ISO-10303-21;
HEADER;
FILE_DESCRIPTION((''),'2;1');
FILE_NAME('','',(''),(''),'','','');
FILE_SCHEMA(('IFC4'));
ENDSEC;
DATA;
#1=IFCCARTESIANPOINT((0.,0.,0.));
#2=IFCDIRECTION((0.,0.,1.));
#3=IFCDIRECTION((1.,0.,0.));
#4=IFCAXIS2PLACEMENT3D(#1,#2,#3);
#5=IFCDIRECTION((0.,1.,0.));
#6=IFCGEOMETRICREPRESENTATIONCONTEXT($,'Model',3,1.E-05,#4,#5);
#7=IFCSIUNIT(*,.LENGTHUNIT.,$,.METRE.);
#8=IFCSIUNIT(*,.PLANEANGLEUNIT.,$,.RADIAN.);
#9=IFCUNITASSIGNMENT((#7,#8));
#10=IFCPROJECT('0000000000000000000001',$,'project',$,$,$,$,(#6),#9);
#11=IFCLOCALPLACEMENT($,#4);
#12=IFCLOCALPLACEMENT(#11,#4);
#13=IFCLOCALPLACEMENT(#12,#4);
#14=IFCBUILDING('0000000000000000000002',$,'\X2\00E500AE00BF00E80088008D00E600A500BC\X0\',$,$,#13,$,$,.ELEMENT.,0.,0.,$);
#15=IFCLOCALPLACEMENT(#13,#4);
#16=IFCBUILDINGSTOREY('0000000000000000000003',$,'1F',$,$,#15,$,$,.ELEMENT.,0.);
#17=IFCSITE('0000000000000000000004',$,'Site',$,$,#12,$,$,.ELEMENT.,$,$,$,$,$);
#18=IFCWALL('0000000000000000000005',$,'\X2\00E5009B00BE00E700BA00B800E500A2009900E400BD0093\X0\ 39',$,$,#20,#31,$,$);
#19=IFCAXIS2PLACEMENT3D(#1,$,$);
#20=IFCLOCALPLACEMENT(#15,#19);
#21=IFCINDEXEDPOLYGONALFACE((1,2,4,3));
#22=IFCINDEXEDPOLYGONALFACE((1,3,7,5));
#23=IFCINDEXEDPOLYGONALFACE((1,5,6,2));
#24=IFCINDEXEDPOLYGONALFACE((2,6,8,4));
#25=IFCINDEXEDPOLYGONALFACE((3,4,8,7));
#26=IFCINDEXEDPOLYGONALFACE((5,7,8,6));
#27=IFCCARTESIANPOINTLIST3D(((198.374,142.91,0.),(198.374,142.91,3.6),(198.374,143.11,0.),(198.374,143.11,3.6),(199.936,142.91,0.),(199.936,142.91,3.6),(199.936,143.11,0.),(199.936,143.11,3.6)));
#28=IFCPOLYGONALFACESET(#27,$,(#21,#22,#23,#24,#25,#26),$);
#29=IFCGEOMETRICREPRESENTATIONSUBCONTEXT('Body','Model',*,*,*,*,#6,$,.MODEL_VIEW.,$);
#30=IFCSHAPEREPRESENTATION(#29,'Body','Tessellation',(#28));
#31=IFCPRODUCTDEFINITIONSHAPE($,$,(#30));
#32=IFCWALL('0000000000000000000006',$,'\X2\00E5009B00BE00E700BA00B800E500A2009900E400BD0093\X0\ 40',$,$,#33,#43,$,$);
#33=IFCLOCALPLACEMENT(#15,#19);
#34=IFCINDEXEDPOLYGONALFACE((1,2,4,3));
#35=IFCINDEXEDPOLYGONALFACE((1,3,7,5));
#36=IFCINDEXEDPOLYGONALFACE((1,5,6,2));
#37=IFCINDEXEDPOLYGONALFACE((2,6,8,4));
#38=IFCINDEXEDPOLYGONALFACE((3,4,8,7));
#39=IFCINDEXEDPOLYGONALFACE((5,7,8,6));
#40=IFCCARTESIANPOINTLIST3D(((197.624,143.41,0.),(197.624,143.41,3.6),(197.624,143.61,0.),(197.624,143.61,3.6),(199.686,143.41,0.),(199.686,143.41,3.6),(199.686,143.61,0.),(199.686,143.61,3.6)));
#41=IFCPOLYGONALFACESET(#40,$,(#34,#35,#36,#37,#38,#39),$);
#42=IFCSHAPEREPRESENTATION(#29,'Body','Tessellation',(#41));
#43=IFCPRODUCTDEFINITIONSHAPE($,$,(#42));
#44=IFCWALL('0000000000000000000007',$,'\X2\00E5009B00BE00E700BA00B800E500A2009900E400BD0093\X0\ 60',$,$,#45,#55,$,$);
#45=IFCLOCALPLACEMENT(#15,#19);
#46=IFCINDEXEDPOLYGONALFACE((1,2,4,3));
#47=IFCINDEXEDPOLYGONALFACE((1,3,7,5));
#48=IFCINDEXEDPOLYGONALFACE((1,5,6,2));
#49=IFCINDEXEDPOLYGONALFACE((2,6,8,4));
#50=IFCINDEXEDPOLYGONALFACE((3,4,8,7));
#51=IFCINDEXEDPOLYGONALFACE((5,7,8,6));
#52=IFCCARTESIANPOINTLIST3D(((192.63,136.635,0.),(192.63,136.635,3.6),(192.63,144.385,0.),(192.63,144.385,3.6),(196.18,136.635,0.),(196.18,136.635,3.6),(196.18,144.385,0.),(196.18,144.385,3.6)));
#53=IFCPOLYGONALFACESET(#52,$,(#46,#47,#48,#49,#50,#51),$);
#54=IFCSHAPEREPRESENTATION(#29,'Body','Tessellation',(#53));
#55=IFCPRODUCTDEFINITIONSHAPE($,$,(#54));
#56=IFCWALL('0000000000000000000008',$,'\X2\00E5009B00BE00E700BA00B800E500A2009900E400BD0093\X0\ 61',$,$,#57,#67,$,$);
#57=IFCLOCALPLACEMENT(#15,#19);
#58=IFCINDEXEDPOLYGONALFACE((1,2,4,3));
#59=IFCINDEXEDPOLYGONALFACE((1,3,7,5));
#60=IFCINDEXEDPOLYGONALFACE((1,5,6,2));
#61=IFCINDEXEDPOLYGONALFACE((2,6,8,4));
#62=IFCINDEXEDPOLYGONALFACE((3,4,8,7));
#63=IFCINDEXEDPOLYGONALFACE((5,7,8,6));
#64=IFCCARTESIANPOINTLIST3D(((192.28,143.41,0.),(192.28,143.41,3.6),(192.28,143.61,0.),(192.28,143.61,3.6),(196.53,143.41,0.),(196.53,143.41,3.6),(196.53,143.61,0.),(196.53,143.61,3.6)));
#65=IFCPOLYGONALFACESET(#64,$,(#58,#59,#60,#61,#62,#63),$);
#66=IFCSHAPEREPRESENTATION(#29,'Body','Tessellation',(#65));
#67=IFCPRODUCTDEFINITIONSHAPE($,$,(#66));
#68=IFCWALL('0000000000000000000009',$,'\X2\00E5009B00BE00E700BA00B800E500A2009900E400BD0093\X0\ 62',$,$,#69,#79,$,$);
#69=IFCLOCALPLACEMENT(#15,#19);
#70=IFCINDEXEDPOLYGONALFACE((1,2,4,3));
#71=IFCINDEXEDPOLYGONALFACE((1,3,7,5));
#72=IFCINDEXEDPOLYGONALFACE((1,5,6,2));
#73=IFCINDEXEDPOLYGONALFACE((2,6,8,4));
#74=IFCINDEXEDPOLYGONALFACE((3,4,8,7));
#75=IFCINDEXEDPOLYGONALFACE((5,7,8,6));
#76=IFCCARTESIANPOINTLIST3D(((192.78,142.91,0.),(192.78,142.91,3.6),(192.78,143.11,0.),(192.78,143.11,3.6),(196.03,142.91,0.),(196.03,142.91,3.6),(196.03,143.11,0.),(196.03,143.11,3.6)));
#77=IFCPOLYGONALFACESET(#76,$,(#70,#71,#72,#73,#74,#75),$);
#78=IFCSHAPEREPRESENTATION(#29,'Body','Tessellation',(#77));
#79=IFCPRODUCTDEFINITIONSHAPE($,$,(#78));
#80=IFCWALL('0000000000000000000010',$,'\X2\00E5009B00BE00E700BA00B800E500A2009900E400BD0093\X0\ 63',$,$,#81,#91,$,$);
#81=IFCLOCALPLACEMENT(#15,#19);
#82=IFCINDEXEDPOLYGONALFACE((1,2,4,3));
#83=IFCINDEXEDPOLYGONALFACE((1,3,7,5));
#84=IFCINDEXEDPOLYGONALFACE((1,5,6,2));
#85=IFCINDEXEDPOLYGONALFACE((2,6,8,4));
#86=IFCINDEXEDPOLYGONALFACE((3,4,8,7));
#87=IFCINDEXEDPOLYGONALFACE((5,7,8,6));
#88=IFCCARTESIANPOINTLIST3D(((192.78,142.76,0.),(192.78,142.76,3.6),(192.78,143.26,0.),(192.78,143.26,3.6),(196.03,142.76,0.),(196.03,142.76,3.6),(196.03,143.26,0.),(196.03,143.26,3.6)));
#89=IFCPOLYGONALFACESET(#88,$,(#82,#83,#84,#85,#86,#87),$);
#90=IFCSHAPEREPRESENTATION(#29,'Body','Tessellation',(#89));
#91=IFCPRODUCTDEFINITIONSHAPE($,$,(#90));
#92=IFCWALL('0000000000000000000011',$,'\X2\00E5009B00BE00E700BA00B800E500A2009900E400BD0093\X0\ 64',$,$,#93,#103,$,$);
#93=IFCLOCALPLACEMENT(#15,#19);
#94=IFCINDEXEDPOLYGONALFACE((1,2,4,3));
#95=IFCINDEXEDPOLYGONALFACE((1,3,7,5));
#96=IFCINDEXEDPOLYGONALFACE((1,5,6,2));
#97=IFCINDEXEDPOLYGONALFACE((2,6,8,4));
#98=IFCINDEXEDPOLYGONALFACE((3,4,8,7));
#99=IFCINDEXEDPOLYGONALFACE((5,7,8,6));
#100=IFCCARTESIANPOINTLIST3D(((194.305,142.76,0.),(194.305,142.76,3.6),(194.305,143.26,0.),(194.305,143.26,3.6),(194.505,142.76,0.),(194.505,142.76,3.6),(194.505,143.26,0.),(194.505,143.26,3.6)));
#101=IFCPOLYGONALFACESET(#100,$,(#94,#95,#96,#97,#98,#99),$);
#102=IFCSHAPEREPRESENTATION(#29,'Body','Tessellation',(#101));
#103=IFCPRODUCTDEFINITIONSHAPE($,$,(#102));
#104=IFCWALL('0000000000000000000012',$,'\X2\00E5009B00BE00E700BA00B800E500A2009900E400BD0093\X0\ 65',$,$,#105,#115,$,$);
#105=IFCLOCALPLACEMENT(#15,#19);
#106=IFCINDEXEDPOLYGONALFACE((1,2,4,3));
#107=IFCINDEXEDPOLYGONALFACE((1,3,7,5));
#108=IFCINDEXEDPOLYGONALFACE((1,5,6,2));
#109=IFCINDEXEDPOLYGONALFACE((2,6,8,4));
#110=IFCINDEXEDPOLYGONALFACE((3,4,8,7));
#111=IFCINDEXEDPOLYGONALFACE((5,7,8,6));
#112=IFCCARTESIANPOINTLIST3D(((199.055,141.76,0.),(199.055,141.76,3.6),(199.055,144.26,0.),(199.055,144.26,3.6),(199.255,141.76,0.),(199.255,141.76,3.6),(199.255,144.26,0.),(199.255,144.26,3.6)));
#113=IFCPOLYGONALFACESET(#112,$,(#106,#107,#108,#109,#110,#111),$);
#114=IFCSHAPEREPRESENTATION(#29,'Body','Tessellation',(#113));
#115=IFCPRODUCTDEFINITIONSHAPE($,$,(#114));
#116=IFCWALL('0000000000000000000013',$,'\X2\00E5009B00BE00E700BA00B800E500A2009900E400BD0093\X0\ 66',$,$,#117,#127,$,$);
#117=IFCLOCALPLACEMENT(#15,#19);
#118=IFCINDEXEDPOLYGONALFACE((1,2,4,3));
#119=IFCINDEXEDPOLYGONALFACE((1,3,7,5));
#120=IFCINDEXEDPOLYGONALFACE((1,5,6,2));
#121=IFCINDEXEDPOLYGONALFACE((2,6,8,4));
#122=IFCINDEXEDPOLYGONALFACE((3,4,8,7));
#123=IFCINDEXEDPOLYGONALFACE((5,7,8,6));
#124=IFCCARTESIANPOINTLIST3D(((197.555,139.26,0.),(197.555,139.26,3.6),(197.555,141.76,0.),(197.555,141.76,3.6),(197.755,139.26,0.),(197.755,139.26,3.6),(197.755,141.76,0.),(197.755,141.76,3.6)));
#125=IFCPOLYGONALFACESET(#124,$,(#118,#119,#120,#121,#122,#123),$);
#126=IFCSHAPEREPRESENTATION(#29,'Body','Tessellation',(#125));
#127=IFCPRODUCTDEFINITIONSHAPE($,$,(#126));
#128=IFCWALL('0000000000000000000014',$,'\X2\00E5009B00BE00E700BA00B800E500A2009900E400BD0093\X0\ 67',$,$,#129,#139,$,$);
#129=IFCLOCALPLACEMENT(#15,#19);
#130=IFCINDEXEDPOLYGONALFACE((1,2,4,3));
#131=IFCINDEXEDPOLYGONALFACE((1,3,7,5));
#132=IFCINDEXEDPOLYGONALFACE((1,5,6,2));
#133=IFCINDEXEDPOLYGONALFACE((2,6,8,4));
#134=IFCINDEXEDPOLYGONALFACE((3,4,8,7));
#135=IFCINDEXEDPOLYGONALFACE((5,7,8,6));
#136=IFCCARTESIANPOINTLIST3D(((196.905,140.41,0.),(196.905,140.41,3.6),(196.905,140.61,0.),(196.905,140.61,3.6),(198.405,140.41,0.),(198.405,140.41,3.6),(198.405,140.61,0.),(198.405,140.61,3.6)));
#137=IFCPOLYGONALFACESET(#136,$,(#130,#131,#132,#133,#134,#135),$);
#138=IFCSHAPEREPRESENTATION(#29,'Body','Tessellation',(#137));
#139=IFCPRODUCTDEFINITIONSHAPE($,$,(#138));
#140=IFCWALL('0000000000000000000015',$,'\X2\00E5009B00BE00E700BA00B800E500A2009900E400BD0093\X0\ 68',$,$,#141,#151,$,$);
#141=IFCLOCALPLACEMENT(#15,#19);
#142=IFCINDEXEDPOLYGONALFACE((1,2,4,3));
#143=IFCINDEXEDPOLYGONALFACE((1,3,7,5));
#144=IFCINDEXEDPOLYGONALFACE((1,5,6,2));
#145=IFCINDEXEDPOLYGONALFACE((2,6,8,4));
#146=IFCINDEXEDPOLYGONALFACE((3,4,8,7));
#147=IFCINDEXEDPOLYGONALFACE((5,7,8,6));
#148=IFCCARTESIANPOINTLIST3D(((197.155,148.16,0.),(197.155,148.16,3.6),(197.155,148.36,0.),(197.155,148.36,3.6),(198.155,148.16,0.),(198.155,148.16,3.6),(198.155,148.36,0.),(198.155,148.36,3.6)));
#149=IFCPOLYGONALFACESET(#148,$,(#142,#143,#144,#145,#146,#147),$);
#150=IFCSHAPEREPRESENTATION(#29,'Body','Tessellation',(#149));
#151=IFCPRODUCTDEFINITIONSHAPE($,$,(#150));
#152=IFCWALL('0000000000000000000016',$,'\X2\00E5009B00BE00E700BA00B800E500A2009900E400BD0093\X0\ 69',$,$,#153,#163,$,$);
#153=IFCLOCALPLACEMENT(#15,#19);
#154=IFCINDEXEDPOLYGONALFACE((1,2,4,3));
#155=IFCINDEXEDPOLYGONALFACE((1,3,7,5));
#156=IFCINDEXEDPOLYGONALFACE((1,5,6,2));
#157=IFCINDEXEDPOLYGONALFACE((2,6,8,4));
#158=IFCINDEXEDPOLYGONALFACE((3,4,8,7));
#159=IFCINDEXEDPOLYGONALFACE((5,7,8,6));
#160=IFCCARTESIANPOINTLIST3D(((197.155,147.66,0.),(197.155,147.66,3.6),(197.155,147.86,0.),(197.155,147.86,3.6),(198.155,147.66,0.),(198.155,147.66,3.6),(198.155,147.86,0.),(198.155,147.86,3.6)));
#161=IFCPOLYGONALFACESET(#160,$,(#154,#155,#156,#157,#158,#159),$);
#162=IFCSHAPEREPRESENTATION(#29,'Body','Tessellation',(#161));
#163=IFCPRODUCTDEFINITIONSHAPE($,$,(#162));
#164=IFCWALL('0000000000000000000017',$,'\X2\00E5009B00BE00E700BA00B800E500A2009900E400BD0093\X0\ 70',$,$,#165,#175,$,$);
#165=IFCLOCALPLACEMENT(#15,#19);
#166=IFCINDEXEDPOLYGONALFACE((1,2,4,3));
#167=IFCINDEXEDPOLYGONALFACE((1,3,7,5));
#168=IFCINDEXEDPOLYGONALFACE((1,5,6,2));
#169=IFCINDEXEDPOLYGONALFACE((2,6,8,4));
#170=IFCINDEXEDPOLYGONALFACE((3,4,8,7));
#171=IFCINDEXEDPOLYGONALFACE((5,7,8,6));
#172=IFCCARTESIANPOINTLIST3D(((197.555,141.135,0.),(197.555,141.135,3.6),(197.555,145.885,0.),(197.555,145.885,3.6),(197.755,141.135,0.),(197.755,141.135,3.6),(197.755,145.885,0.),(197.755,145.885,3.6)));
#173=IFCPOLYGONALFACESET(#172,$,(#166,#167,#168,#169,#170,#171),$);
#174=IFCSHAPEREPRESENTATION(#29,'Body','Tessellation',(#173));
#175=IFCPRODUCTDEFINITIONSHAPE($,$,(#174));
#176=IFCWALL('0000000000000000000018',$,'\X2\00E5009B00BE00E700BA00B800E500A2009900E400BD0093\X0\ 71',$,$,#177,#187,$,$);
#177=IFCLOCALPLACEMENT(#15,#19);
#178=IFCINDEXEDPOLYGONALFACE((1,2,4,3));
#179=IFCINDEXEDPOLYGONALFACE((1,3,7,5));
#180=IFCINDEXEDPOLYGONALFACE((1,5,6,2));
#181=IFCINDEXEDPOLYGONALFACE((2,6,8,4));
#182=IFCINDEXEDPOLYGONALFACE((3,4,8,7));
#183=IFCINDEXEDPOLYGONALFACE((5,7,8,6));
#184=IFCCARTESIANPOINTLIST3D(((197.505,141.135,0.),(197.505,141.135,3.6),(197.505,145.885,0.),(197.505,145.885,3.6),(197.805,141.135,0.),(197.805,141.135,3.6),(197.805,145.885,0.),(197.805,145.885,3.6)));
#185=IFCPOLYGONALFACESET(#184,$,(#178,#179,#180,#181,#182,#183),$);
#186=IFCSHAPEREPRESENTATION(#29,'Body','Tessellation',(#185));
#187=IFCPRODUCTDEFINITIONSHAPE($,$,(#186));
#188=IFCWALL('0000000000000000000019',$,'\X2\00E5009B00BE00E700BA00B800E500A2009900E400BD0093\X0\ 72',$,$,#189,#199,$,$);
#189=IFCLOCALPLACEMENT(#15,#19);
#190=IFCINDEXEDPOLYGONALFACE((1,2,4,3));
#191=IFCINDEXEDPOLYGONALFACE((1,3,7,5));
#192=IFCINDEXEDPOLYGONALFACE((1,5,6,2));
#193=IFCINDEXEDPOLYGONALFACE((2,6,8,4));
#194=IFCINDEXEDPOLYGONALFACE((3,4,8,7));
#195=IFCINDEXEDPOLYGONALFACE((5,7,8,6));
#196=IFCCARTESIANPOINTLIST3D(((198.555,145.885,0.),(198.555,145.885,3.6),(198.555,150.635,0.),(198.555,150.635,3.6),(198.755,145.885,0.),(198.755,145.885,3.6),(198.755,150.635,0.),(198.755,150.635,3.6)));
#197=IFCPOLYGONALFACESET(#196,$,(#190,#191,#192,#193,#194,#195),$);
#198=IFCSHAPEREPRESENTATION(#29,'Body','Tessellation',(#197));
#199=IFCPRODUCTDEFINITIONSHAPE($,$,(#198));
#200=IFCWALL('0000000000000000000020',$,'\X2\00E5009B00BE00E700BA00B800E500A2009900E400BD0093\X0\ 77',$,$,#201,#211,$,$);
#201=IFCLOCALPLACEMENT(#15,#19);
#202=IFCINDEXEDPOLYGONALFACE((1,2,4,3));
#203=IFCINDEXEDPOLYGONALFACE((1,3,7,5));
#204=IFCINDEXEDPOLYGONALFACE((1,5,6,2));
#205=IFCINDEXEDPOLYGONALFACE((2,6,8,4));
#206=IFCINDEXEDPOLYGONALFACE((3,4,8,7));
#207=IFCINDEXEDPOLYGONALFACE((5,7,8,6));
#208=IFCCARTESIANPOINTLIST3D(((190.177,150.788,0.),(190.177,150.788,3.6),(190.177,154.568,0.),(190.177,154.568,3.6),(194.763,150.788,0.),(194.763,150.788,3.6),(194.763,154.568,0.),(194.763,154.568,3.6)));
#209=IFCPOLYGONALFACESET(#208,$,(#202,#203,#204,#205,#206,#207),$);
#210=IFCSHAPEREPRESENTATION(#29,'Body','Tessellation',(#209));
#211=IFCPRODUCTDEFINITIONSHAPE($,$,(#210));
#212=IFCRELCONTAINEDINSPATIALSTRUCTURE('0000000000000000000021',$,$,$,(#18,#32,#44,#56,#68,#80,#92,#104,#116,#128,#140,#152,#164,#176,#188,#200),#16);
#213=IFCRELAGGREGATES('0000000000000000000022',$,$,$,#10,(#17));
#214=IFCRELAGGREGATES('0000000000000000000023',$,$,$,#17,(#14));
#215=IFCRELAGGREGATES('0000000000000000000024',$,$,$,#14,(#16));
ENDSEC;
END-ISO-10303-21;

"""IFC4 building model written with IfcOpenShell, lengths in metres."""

from ifc_helpers import new_model, si_unit, direction, frame, frame_2d, origin_with_axes, place, context, subcontext, project, spatial, rectangle, extrude, element, save


model = new_model("IFC4")

# Units and contexts
model_context = context("Model", 3, precision=1e-05, world=origin_with_axes(), true_north=direction((0.0, 1.0, 0.0)))
body_context = subcontext(model_context, "Body", "Model", "MODEL_VIEW")
ifc_project = project(units=[si_unit("LENGTHUNIT", "METRE"), si_unit("PLANEANGLEUNIT", "RADIAN")], contexts=[model_context])

# Site, building, storey
placement = place(None, origin_with_axes())
site_placement = place(placement, origin_with_axes())
site = spatial("IfcSite", under=ifc_project, at=site_placement, Name="Site", CompositionType="ELEMENT")
building_placement = place(site_placement, origin_with_axes())
building = spatial("IfcBuilding", under=site, at=building_placement, Name="å®¿è\u0088\u008dæ¥¼", CompositionType="ELEMENT", ElevationOfRefHeight=0.0, ElevationOfTerrain=0.0)
storey_placement = place(building_placement, origin_with_axes())
storey = spatial("IfcBuildingStorey", under=building, at=storey_placement, Name="1F", CompositionType="ELEMENT", Elevation=0.0)

# Walls
wall_1_placement = place(storey_placement, frame((199.155, 143.01, 0.0), z_axis=(0.0, 0.0, 1.0), x_axis=(1.0, 0.0, 0.0)))
element("IfcWall", 1, at=wall_1_placement, inside=storey, Name="å\u009b¾çº¸å¢\u0099ä½\u0093 39", context=body_context, shape_type="SweptSolid", body=[
    extrude(rectangle(XDim=1.562, YDim=0.2, at=frame_2d((0.0, 0.0), x_axis=(1.0, 0.0, 0.0))), frame((0.0, 0.0, 0.0), z_axis=(0.0, 0.0, 1.0)), (0.0, 0.0, 1.0), 3.6),
])
wall_2_placement = place(storey_placement, frame((198.655, 143.51, 0.0), z_axis=(0.0, 0.0, 1.0), x_axis=(1.0, 0.0, 0.0)))
element("IfcWall", 2, at=wall_2_placement, inside=storey, Name="å\u009b¾çº¸å¢\u0099ä½\u0093 40", context=body_context, shape_type="SweptSolid", body=[
    extrude(rectangle(XDim=2.062, YDim=0.2, at=frame_2d((0.0, 0.0), x_axis=(1.0, 0.0, 0.0))), frame((0.0, 0.0, 0.0), z_axis=(0.0, 0.0, 1.0)), (0.0, 0.0, 1.0), 3.6),
])
wall_3_placement = place(storey_placement, frame((194.405, 140.51, 0.0), z_axis=(0.0, 0.0, 1.0), x_axis=(1.0, 0.0, 0.0)))
element("IfcWall", 3, at=wall_3_placement, inside=storey, Name="å\u009b¾çº¸å¢\u0099ä½\u0093 60", context=body_context, shape_type="SweptSolid", body=[
    extrude(rectangle(XDim=3.55, YDim=7.75, at=frame_2d((0.0, 0.0), x_axis=(1.0, 0.0, 0.0))), frame((0.0, 0.0, 0.0), z_axis=(0.0, 0.0, 1.0)), (0.0, 0.0, 1.0), 3.6),
])
wall_4_placement = place(storey_placement, frame((194.405, 143.51, 0.0), z_axis=(0.0, 0.0, 1.0), x_axis=(1.0, 0.0, 0.0)))
element("IfcWall", 4, at=wall_4_placement, inside=storey, Name="å\u009b¾çº¸å¢\u0099ä½\u0093 61", context=body_context, shape_type="SweptSolid", body=[
    extrude(rectangle(XDim=4.25, YDim=0.2, at=frame_2d((0.0, 0.0), x_axis=(1.0, 0.0, 0.0))), frame((0.0, 0.0, 0.0), z_axis=(0.0, 0.0, 1.0)), (0.0, 0.0, 1.0), 3.6),
])
wall_5_placement = place(storey_placement, frame((194.405, 143.01, 0.0), z_axis=(0.0, 0.0, 1.0), x_axis=(1.0, 0.0, 0.0)))
element("IfcWall", 5, at=wall_5_placement, inside=storey, Name="å\u009b¾çº¸å¢\u0099ä½\u0093 62", context=body_context, shape_type="SweptSolid", body=[
    extrude(rectangle(XDim=3.25, YDim=0.2, at=frame_2d((0.0, 0.0), x_axis=(1.0, 0.0, 0.0))), frame((0.0, 0.0, 0.0), z_axis=(0.0, 0.0, 1.0)), (0.0, 0.0, 1.0), 3.6),
])
wall_6_placement = place(storey_placement, frame((194.405, 143.01, 0.0), z_axis=(0.0, 0.0, 1.0), x_axis=(1.0, 0.0, 0.0)))
element("IfcWall", 6, at=wall_6_placement, inside=storey, Name="å\u009b¾çº¸å¢\u0099ä½\u0093 63", context=body_context, shape_type="SweptSolid", body=[
    extrude(rectangle(XDim=3.25, YDim=0.5, at=frame_2d((0.0, 0.0), x_axis=(1.0, 0.0, 0.0))), frame((0.0, 0.0, 0.0), z_axis=(0.0, 0.0, 1.0)), (0.0, 0.0, 1.0), 3.6),
])
wall_7_placement = place(storey_placement, frame((194.405, 143.01, 0.0), z_axis=(0.0, 0.0, 1.0), x_axis=(0.0, 1.0, 0.0)))
element("IfcWall", 7, at=wall_7_placement, inside=storey, Name="å\u009b¾çº¸å¢\u0099ä½\u0093 64", context=body_context, shape_type="SweptSolid", body=[
    extrude(rectangle(XDim=0.5, YDim=0.2, at=frame_2d((0.0, 0.0), x_axis=(1.0, 0.0, 0.0))), frame((0.0, 0.0, 0.0), z_axis=(0.0, 0.0, 1.0)), (0.0, 0.0, 1.0), 3.6),
])
for number, where, z_axis, x_axis, name in (
    (8, (199.155, 143.01, 0.0), (0.0, 0.0, 1.0), (0.0, -1.0, 0.0), "å\u009b¾çº¸å¢\u0099ä½\u0093 65"),
    (9, (197.655, 140.51, 0.0), (0.0, 0.0, 1.0), (0.0, 1.0, 0.0), "å\u009b¾çº¸å¢\u0099ä½\u0093 66"),
):
    element("IfcWall", number, at=place(storey_placement, frame(where, z_axis=z_axis, x_axis=x_axis)), inside=storey, Name=name, context=body_context, shape_type="SweptSolid", body=[
        extrude(rectangle(XDim=2.5, YDim=0.2, at=frame_2d((0.0, 0.0), x_axis=(1.0, 0.0, 0.0))), frame((0.0, 0.0, 0.0), z_axis=(0.0, 0.0, 1.0)), (0.0, 0.0, 1.0), 3.6),
    ])
wall_8_placement = place(storey_placement, frame((197.655, 140.51, 0.0), z_axis=(0.0, 0.0, 1.0), x_axis=(1.0, 0.0, 0.0)))
element("IfcWall", 10, at=wall_8_placement, inside=storey, Name="å\u009b¾çº¸å¢\u0099ä½\u0093 67", context=body_context, shape_type="SweptSolid", body=[
    extrude(rectangle(XDim=1.5, YDim=0.2, at=frame_2d((0.0, 0.0), x_axis=(1.0, 0.0, 0.0))), frame((0.0, 0.0, 0.0), z_axis=(0.0, 0.0, 1.0)), (0.0, 0.0, 1.0), 3.6),
])
for number, where, z_axis, x_axis, name in (
    (11, (197.655, 148.26, 0.0), (0.0, 0.0, 1.0), (1.0, 0.0, 0.0), "å\u009b¾çº¸å¢\u0099ä½\u0093 68"),
    (12, (197.655, 147.76, 0.0), (0.0, 0.0, 1.0), (1.0, 0.0, 0.0), "å\u009b¾çº¸å¢\u0099ä½\u0093 69"),
):
    element("IfcWall", number, at=place(storey_placement, frame(where, z_axis=z_axis, x_axis=x_axis)), inside=storey, Name=name, context=body_context, shape_type="SweptSolid", body=[
        extrude(rectangle(XDim=1.0, YDim=0.2, at=frame_2d((0.0, 0.0), x_axis=(1.0, 0.0, 0.0))), frame((0.0, 0.0, 0.0), z_axis=(0.0, 0.0, 1.0)), (0.0, 0.0, 1.0), 3.6),
    ])
wall_9_placement = place(storey_placement, frame((197.655, 143.51, 0.0), z_axis=(0.0, 0.0, 1.0), x_axis=(0.0, 1.0, 0.0)))
element("IfcWall", 13, at=wall_9_placement, inside=storey, Name="å\u009b¾çº¸å¢\u0099ä½\u0093 70", context=body_context, shape_type="SweptSolid", body=[
    extrude(rectangle(XDim=4.75, YDim=0.2, at=frame_2d((0.0, 0.0), x_axis=(1.0, 0.0, 0.0))), frame((0.0, 0.0, 0.0), z_axis=(0.0, 0.0, 1.0)), (0.0, 0.0, 1.0), 3.6),
])
wall_10_placement = place(storey_placement, frame((197.655, 143.51, 0.0), z_axis=(0.0, 0.0, 1.0), x_axis=(1.0, 0.0, 0.0)))
element("IfcWall", 14, at=wall_10_placement, inside=storey, Name="å\u009b¾çº¸å¢\u0099ä½\u0093 71", context=body_context, shape_type="SweptSolid", body=[
    extrude(rectangle(XDim=0.3, YDim=4.75, at=frame_2d((0.0, 0.0), x_axis=(1.0, 0.0, 0.0))), frame((0.0, 0.0, 0.0), z_axis=(0.0, 0.0, 1.0)), (0.0, 0.0, 1.0), 3.6),
])
wall_11_placement = place(storey_placement, frame((198.655, 148.26, 0.0), z_axis=(0.0, 0.0, 1.0), x_axis=(0.0, -1.0, 0.0)))
element("IfcWall", 15, at=wall_11_placement, inside=storey, Name="å\u009b¾çº¸å¢\u0099ä½\u0093 72", context=body_context, shape_type="SweptSolid", body=[
    extrude(rectangle(XDim=4.75, YDim=0.2, at=frame_2d((0.0, 0.0), x_axis=(1.0, 0.0, 0.0))), frame((0.0, 0.0, 0.0), z_axis=(0.0, 0.0, 1.0)), (0.0, 0.0, 1.0), 3.6),
])
wall_12_placement = place(storey_placement, frame((192.47, 152.678, 0.0), z_axis=(0.0, 0.0, 1.0), x_axis=(1.0, 0.0, 0.0)))
element("IfcWall", 16, at=wall_12_placement, inside=storey, Name="å\u009b¾çº¸å¢\u0099ä½\u0093 77", context=body_context, shape_type="SweptSolid", body=[
    extrude(rectangle(XDim=4.586, YDim=3.78, at=frame_2d((0.0, 0.0), x_axis=(1.0, 0.0, 0.0))), frame((0.0, 0.0, 0.0), z_axis=(0.0, 0.0, 1.0)), (0.0, 0.0, 1.0), 3.6),
])

save(model, "model.ifc")
